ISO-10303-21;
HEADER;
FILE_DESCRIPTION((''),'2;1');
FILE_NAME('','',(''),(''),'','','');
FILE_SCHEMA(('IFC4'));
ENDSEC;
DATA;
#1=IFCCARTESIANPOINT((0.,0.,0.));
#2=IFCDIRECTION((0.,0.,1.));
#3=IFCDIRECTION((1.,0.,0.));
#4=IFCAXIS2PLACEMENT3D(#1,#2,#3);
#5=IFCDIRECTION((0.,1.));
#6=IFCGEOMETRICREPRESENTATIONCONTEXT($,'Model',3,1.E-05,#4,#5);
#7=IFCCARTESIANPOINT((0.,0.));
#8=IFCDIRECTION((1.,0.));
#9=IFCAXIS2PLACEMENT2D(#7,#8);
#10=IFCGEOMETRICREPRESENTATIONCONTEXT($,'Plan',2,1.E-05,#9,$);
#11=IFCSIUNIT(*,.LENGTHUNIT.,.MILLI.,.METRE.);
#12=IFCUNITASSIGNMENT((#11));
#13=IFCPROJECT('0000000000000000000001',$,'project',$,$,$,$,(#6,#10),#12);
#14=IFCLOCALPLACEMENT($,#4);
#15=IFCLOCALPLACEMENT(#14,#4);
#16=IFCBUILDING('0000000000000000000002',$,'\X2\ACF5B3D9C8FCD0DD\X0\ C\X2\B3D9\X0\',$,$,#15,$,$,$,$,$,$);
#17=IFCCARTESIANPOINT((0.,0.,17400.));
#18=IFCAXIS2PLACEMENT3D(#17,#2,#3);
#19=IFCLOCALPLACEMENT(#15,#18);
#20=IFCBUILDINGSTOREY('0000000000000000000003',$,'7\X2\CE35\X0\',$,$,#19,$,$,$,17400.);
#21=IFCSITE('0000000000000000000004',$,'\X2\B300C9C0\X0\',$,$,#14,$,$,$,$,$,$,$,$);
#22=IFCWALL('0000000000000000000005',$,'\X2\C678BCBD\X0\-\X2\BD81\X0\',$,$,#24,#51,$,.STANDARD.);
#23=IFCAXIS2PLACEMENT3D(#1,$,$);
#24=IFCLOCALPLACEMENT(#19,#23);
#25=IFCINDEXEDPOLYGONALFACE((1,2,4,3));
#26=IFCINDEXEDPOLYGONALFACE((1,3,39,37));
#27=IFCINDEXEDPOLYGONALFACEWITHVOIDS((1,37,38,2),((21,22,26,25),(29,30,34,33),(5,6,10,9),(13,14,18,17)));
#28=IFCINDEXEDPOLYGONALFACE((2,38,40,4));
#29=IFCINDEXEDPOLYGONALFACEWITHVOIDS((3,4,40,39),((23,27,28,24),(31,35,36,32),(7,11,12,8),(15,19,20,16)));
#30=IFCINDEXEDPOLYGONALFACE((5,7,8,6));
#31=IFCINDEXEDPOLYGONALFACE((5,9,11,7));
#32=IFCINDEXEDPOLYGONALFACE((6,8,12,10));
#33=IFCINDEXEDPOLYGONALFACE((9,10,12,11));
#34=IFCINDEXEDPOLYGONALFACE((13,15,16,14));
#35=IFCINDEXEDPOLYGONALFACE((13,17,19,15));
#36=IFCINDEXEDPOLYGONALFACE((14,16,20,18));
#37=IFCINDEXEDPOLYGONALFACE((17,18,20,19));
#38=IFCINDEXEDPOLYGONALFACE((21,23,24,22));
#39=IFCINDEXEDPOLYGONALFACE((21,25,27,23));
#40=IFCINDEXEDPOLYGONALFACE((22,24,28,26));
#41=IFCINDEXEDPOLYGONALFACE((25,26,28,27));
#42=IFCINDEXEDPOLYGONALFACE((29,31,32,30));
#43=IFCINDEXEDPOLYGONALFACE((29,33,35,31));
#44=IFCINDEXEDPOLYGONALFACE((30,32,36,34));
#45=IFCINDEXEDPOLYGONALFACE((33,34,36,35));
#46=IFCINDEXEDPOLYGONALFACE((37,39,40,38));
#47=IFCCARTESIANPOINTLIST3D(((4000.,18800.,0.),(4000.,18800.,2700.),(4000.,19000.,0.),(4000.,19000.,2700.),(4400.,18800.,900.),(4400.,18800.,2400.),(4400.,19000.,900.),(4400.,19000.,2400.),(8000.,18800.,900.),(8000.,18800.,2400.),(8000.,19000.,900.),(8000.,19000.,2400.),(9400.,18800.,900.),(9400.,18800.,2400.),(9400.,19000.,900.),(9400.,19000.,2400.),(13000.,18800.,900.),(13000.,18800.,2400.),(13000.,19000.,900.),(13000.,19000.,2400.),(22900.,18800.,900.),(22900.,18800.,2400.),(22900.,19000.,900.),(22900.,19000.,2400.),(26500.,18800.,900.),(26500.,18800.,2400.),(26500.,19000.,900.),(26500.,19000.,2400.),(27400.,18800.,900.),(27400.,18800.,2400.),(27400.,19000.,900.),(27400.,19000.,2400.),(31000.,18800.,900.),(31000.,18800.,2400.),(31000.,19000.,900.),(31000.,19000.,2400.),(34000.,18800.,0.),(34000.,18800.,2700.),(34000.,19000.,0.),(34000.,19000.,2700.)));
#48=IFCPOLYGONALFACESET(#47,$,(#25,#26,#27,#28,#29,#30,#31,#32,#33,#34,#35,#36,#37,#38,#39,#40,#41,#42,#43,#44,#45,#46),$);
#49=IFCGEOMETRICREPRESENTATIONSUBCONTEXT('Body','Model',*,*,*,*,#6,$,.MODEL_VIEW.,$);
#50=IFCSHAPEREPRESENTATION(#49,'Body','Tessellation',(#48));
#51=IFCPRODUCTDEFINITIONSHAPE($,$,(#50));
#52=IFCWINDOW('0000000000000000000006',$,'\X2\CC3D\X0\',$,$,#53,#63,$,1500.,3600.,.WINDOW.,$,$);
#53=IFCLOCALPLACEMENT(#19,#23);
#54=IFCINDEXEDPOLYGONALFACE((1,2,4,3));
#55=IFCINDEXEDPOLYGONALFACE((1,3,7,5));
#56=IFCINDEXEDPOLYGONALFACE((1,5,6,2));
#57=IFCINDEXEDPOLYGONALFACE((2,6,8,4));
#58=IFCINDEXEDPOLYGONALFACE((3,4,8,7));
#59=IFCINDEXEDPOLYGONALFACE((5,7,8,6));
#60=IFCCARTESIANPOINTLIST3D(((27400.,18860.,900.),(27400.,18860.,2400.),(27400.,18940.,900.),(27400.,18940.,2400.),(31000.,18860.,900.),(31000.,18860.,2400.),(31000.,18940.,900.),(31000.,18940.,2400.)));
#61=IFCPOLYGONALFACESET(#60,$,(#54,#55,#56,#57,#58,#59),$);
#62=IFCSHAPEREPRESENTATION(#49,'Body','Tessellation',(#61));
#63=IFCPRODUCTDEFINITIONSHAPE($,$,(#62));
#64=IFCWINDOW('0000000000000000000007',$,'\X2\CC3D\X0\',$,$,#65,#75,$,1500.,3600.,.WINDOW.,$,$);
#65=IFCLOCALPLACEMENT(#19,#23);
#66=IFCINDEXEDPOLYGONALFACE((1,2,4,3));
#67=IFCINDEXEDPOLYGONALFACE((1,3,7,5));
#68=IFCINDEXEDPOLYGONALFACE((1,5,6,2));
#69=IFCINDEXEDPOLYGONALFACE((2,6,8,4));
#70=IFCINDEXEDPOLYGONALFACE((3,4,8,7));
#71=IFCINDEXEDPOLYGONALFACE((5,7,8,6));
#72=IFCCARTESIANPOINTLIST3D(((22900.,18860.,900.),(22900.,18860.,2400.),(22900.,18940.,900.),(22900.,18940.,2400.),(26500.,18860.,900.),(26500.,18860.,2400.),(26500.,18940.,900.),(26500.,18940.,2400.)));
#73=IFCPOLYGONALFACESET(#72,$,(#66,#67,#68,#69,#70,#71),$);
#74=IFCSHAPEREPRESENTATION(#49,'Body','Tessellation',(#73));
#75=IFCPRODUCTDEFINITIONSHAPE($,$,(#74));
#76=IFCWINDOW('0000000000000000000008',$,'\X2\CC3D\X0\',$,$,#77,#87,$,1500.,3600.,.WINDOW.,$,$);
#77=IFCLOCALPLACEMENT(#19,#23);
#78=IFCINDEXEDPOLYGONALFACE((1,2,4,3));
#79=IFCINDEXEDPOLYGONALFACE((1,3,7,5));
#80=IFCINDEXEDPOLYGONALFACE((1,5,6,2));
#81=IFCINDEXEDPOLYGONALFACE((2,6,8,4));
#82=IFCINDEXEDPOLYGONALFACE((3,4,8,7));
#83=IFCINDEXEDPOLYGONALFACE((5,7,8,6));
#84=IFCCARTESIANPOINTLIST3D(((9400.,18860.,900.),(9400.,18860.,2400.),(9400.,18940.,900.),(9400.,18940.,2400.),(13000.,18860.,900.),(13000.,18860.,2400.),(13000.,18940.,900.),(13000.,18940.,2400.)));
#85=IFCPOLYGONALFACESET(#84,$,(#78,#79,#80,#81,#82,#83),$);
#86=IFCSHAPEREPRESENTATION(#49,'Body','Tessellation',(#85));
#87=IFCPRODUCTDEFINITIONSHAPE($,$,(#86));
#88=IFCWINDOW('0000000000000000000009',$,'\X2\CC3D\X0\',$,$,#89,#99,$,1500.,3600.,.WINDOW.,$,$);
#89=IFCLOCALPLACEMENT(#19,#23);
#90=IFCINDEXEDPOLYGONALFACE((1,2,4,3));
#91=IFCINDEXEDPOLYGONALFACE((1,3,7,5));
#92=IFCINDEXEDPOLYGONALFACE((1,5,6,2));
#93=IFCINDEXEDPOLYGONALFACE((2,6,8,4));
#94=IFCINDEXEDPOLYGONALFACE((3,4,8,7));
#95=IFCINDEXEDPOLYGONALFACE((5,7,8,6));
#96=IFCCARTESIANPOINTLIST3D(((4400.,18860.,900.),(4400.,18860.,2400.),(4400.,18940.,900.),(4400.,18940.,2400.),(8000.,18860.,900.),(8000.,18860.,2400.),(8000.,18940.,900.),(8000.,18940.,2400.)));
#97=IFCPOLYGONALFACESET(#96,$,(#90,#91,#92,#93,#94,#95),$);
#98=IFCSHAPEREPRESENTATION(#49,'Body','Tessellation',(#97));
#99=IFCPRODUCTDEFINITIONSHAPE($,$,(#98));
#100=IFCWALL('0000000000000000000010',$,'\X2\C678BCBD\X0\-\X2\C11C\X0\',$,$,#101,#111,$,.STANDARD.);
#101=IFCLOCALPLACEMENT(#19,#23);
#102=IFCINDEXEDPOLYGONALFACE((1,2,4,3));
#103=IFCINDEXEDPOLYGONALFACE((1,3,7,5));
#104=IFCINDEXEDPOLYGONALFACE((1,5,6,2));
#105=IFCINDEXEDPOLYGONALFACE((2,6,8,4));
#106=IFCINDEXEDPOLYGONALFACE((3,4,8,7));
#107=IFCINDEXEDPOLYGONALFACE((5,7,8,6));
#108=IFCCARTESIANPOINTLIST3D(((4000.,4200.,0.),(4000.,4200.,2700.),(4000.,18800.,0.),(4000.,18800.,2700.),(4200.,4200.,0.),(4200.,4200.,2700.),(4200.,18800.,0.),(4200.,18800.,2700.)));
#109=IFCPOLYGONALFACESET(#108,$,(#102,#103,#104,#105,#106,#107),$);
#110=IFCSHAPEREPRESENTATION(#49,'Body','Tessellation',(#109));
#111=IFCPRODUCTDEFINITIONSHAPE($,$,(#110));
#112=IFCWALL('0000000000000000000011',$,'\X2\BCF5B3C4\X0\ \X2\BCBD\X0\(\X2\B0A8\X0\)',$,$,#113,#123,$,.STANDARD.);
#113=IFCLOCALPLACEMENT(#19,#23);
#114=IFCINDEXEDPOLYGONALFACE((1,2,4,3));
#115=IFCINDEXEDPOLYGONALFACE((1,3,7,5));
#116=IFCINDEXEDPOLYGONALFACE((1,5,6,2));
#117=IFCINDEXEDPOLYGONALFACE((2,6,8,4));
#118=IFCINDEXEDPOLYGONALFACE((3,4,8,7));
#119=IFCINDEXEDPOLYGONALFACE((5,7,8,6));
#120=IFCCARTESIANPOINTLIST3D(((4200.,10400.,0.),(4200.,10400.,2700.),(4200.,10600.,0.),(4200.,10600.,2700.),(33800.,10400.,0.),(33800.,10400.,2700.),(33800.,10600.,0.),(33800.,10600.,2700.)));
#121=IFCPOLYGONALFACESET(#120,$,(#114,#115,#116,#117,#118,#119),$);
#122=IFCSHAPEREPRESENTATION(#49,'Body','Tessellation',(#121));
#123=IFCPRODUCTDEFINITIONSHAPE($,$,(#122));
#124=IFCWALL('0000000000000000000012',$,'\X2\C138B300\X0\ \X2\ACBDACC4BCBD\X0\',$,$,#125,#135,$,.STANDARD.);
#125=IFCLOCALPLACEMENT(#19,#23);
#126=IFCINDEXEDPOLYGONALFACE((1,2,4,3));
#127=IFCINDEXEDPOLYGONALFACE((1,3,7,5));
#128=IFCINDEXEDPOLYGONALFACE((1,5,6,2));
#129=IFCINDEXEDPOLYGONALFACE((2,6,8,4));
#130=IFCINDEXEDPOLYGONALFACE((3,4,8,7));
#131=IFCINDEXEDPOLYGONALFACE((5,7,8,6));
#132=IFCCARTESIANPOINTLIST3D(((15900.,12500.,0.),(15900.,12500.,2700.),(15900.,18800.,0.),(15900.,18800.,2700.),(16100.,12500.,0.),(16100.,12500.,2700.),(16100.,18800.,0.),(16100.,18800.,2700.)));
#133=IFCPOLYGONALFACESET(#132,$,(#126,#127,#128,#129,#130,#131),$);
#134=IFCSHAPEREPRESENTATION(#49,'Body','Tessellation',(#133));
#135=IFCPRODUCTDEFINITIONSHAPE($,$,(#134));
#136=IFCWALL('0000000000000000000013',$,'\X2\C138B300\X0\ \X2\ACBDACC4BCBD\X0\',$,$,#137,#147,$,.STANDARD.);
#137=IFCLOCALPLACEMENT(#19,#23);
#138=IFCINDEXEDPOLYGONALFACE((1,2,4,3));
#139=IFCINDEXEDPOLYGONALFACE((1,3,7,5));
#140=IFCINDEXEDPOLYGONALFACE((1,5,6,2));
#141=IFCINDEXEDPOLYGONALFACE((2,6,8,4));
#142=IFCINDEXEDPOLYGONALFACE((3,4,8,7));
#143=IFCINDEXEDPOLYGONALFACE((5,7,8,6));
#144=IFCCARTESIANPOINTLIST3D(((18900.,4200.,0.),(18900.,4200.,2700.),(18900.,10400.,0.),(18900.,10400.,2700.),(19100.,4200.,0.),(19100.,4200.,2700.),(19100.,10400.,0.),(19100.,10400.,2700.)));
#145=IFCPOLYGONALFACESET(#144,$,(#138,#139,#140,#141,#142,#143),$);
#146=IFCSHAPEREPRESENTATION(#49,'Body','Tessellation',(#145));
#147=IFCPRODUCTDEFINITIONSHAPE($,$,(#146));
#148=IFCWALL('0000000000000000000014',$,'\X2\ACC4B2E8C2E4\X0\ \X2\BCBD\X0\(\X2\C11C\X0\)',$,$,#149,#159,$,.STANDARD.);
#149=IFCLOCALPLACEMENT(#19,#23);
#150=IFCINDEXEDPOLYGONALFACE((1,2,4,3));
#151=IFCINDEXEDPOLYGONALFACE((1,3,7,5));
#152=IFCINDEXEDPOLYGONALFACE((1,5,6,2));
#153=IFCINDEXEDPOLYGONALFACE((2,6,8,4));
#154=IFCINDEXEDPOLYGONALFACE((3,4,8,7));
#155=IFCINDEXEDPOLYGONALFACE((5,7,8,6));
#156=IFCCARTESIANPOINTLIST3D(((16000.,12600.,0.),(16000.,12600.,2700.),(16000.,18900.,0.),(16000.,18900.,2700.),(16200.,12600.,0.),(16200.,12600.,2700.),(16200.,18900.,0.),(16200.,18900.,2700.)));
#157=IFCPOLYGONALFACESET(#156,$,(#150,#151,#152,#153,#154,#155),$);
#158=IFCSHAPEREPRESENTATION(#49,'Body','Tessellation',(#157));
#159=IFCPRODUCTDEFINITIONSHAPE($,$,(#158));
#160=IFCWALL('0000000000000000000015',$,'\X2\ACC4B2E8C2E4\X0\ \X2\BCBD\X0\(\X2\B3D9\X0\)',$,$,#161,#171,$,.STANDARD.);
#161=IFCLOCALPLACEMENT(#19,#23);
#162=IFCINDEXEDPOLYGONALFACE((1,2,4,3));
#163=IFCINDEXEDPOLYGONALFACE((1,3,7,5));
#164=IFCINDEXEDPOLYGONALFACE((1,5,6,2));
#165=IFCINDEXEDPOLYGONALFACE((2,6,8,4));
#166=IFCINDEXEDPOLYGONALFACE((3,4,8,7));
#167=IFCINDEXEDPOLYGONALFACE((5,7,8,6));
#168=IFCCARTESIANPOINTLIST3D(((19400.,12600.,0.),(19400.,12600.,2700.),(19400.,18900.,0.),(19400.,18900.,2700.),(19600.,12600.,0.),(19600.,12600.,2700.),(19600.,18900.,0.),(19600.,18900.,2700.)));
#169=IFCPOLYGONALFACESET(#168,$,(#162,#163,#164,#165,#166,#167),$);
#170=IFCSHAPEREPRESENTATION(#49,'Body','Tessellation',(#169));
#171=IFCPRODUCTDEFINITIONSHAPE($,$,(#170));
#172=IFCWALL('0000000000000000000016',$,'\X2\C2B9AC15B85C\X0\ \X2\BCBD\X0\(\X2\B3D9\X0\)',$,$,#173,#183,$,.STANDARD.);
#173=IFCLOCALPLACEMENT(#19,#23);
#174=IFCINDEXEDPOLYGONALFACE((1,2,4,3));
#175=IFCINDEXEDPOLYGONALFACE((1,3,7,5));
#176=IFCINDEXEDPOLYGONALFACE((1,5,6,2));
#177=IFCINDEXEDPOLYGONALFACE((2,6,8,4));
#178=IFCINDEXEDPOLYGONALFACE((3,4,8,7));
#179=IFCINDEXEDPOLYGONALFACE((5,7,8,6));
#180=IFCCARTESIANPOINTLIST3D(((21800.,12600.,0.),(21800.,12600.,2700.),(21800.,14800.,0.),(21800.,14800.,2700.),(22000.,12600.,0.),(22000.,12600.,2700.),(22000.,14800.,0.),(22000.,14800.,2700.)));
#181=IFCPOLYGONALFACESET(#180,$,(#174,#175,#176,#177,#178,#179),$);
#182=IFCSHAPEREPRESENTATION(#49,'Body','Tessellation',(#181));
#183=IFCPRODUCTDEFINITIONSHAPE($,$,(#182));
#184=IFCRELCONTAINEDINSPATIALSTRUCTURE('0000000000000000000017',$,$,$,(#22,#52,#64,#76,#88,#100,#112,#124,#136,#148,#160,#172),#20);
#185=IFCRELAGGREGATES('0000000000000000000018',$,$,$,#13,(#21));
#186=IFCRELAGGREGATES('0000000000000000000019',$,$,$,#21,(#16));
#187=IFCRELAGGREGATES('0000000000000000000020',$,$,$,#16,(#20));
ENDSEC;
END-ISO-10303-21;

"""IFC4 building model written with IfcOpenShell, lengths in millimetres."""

from ifc_helpers import new_model, si_unit, direction, frame, origin_with_axes, origin_2d_with_axis, place, context, subcontext, project, spatial, polyline, outline, extrude, element, fill, save


model = new_model("IFC4")

# Units and contexts
model_context = context("Model", 3, precision=1e-05, world=origin_with_axes(), true_north=direction((0.0, 1.0)))
plan_context = context("Plan", 2, precision=1e-05, world=origin_2d_with_axis())
body_context = subcontext(model_context, "Body", "Model", "MODEL_VIEW")
ifc_project = project(units=[si_unit("LENGTHUNIT", "METRE", prefix="MILLI")], contexts=[model_context, plan_context])

# Site, building, storey
site_placement = place(None, origin_with_axes())
site = spatial("IfcSite", under=ifc_project, at=site_placement, Name="대지")
building_placement = place(site_placement, origin_with_axes())
building = spatial("IfcBuilding", under=site, at=building_placement, Name="공동주택 C동")
storey_placement = place(building_placement, frame((0.0, 0.0, 17400.0), z_axis=(0.0, 0.0, 1.0), x_axis=(1.0, 0.0, 0.0)))
storey = spatial("IfcBuildingStorey", under=building, at=storey_placement, Name="7층", Elevation=17400.0)

# Wall, openings, windows
wall_1_placement = place(storey_placement, origin_with_axes())
wall_1 = element("IfcWall", 1, at=wall_1_placement, inside=storey, Name="외벽-북", PredefinedType="STANDARD", context=body_context, shape_type="SweptSolid", body=[
    extrude(outline(polyline([(34000.0, 18800.0), (4000.0, 18800.0), (4000.0, 19000.0), (34000.0, 19000.0), (34000.0, 18800.0)])), origin_with_axes(), (0.0, 0.0, 1.0), 2700.0),
])
opening_1_placement = place(storey_placement, origin_with_axes())
opening_1 = element("IfcOpeningElement", 2, at=opening_1_placement, cuts=wall_1, PredefinedType="OPENING", context=body_context, shape_type="SweptSolid", body=[
    extrude(outline(polyline([(31000.0, 19050.0), (27400.0, 19050.0), (27400.0, 18750.0), (31000.0, 18750.0), (31000.0, 19050.0)])), frame((0.0, 0.0, 900.0), z_axis=(0.0, 0.0, 1.0), x_axis=(1.0, 0.0, 0.0)), (0.0, 0.0, 1.0), 1500.0),
])
opening_2_placement = place(storey_placement, origin_with_axes())
opening_2 = element("IfcOpeningElement", 3, at=opening_2_placement, cuts=wall_1, PredefinedType="OPENING", context=body_context, shape_type="SweptSolid", body=[
    extrude(outline(polyline([(26500.0, 19050.0), (22900.0, 19050.0), (22900.0, 18750.0), (26500.0, 18750.0), (26500.0, 19050.0)])), frame((0.0, 0.0, 900.0), z_axis=(0.0, 0.0, 1.0), x_axis=(1.0, 0.0, 0.0)), (0.0, 0.0, 1.0), 1500.0),
])
opening_3_placement = place(storey_placement, origin_with_axes())
opening_3 = element("IfcOpeningElement", 4, at=opening_3_placement, cuts=wall_1, PredefinedType="OPENING", context=body_context, shape_type="SweptSolid", body=[
    extrude(outline(polyline([(13000.0, 19050.0), (9400.0, 19050.0), (9400.0, 18750.0), (13000.0, 18750.0), (13000.0, 19050.0)])), frame((0.0, 0.0, 900.0), z_axis=(0.0, 0.0, 1.0), x_axis=(1.0, 0.0, 0.0)), (0.0, 0.0, 1.0), 1500.0),
])
opening_4_placement = place(storey_placement, origin_with_axes())
opening_4 = element("IfcOpeningElement", 5, at=opening_4_placement, cuts=wall_1, PredefinedType="OPENING", context=body_context, shape_type="SweptSolid", body=[
    extrude(outline(polyline([(8000.0, 19050.0), (4400.0, 19050.0), (4400.0, 18750.0), (8000.0, 18750.0), (8000.0, 19050.0)])), frame((0.0, 0.0, 900.0), z_axis=(0.0, 0.0, 1.0), x_axis=(1.0, 0.0, 0.0)), (0.0, 0.0, 1.0), 1500.0),
])
window_1_placement = place(storey_placement, origin_with_axes())
window_1 = element("IfcWindow", 6, at=window_1_placement, inside=storey, Name="창", OverallHeight=1500.0, OverallWidth=3600.0, PredefinedType="WINDOW", context=body_context, shape_type="SweptSolid", body=[
    extrude(outline(polyline([(31000.0, 18940.0), (27400.0, 18940.0), (27400.0, 18860.0), (31000.0, 18860.0), (31000.0, 18940.0)])), frame((0.0, 0.0, 900.0), z_axis=(0.0, 0.0, 1.0), x_axis=(1.0, 0.0, 0.0)), (0.0, 0.0, 1.0), 1500.0),
])
fill(opening_1, window_1)
window_2_placement = place(storey_placement, origin_with_axes())
window_2 = element("IfcWindow", 7, at=window_2_placement, inside=storey, Name="창", OverallHeight=1500.0, OverallWidth=3600.0, PredefinedType="WINDOW", context=body_context, shape_type="SweptSolid", body=[
    extrude(outline(polyline([(26500.0, 18940.0), (22900.0, 18940.0), (22900.0, 18860.0), (26500.0, 18860.0), (26500.0, 18940.0)])), frame((0.0, 0.0, 900.0), z_axis=(0.0, 0.0, 1.0), x_axis=(1.0, 0.0, 0.0)), (0.0, 0.0, 1.0), 1500.0),
])
fill(opening_2, window_2)
window_3_placement = place(storey_placement, origin_with_axes())
window_3 = element("IfcWindow", 8, at=window_3_placement, inside=storey, Name="창", OverallHeight=1500.0, OverallWidth=3600.0, PredefinedType="WINDOW", context=body_context, shape_type="SweptSolid", body=[
    extrude(outline(polyline([(13000.0, 18940.0), (9400.0, 18940.0), (9400.0, 18860.0), (13000.0, 18860.0), (13000.0, 18940.0)])), frame((0.0, 0.0, 900.0), z_axis=(0.0, 0.0, 1.0), x_axis=(1.0, 0.0, 0.0)), (0.0, 0.0, 1.0), 1500.0),
])
fill(opening_3, window_3)
window_4_placement = place(storey_placement, origin_with_axes())
window_4 = element("IfcWindow", 9, at=window_4_placement, inside=storey, Name="창", OverallHeight=1500.0, OverallWidth=3600.0, PredefinedType="WINDOW", context=body_context, shape_type="SweptSolid", body=[
    extrude(outline(polyline([(8000.0, 18940.0), (4400.0, 18940.0), (4400.0, 18860.0), (8000.0, 18860.0), (8000.0, 18940.0)])), frame((0.0, 0.0, 900.0), z_axis=(0.0, 0.0, 1.0), x_axis=(1.0, 0.0, 0.0)), (0.0, 0.0, 1.0), 1500.0),
])
fill(opening_4, window_4)

# Walls
wall_2_placement = place(storey_placement, origin_with_axes())
element("IfcWall", 10, at=wall_2_placement, inside=storey, Name="외벽-서", PredefinedType="STANDARD", context=body_context, shape_type="SweptSolid", body=[
    extrude(outline(polyline([(4200.0, 18800.0), (4200.0, 4200.0), (4000.0, 4200.0), (4000.0, 18800.0), (4200.0, 18800.0)])), origin_with_axes(), (0.0, 0.0, 1.0), 2700.0),
])
wall_3_placement = place(storey_placement, origin_with_axes())
element("IfcWall", 11, at=wall_3_placement, inside=storey, Name="복도 벽(남)", PredefinedType="STANDARD", context=body_context, shape_type="SweptSolid", body=[
    extrude(outline(polyline([(4200.0, 10600.0), (33800.0, 10600.0), (33800.0, 10400.0), (4200.0, 10400.0), (4200.0, 10600.0)])), origin_with_axes(), (0.0, 0.0, 1.0), 2700.0),
])
wall_4_placement = place(storey_placement, origin_with_axes())
element("IfcWall", 12, at=wall_4_placement, inside=storey, Name="세대 경계벽", PredefinedType="STANDARD", context=body_context, shape_type="SweptSolid", body=[
    extrude(outline(polyline([(15900.0, 12500.0), (15900.0, 18800.0), (16100.0, 18800.0), (16100.0, 12500.0), (15900.0, 12500.0)])), origin_with_axes(), (0.0, 0.0, 1.0), 2700.0),
])
wall_5_placement = place(storey_placement, origin_with_axes())
element("IfcWall", 13, at=wall_5_placement, inside=storey, Name="세대 경계벽", PredefinedType="STANDARD", context=body_context, shape_type="SweptSolid", body=[
    extrude(outline(polyline([(18900.0, 4200.0), (18900.0, 10400.0), (19100.0, 10400.0), (19100.0, 4200.0), (18900.0, 4200.0)])), origin_with_axes(), (0.0, 0.0, 1.0), 2700.0),
])
wall_6_placement = place(storey_placement, origin_with_axes())
element("IfcWall", 14, at=wall_6_placement, inside=storey, Name="계단실 벽(서)", PredefinedType="STANDARD", context=body_context, shape_type="SweptSolid", body=[
    extrude(outline(polyline([(16000.0, 12600.0), (16000.0, 18900.0), (16200.0, 18900.0), (16200.0, 12600.0), (16000.0, 12600.0)])), origin_with_axes(), (0.0, 0.0, 1.0), 2700.0),
])
wall_7_placement = place(storey_placement, origin_with_axes())
element("IfcWall", 15, at=wall_7_placement, inside=storey, Name="계단실 벽(동)", PredefinedType="STANDARD", context=body_context, shape_type="SweptSolid", body=[
    extrude(outline(polyline([(19400.0, 12600.0), (19400.0, 18900.0), (19600.0, 18900.0), (19600.0, 12600.0), (19400.0, 12600.0)])), origin_with_axes(), (0.0, 0.0, 1.0), 2700.0),
])
wall_8_placement = place(storey_placement, origin_with_axes())
element("IfcWall", 16, at=wall_8_placement, inside=storey, Name="승강로 벽(동)", PredefinedType="STANDARD", context=body_context, shape_type="SweptSolid", body=[
    extrude(outline(polyline([(21800.0, 12600.0), (21800.0, 14800.0), (22000.0, 14800.0), (22000.0, 12600.0), (21800.0, 12600.0)])), origin_with_axes(), (0.0, 0.0, 1.0), 2700.0),
])

save(model, "model.ifc")
